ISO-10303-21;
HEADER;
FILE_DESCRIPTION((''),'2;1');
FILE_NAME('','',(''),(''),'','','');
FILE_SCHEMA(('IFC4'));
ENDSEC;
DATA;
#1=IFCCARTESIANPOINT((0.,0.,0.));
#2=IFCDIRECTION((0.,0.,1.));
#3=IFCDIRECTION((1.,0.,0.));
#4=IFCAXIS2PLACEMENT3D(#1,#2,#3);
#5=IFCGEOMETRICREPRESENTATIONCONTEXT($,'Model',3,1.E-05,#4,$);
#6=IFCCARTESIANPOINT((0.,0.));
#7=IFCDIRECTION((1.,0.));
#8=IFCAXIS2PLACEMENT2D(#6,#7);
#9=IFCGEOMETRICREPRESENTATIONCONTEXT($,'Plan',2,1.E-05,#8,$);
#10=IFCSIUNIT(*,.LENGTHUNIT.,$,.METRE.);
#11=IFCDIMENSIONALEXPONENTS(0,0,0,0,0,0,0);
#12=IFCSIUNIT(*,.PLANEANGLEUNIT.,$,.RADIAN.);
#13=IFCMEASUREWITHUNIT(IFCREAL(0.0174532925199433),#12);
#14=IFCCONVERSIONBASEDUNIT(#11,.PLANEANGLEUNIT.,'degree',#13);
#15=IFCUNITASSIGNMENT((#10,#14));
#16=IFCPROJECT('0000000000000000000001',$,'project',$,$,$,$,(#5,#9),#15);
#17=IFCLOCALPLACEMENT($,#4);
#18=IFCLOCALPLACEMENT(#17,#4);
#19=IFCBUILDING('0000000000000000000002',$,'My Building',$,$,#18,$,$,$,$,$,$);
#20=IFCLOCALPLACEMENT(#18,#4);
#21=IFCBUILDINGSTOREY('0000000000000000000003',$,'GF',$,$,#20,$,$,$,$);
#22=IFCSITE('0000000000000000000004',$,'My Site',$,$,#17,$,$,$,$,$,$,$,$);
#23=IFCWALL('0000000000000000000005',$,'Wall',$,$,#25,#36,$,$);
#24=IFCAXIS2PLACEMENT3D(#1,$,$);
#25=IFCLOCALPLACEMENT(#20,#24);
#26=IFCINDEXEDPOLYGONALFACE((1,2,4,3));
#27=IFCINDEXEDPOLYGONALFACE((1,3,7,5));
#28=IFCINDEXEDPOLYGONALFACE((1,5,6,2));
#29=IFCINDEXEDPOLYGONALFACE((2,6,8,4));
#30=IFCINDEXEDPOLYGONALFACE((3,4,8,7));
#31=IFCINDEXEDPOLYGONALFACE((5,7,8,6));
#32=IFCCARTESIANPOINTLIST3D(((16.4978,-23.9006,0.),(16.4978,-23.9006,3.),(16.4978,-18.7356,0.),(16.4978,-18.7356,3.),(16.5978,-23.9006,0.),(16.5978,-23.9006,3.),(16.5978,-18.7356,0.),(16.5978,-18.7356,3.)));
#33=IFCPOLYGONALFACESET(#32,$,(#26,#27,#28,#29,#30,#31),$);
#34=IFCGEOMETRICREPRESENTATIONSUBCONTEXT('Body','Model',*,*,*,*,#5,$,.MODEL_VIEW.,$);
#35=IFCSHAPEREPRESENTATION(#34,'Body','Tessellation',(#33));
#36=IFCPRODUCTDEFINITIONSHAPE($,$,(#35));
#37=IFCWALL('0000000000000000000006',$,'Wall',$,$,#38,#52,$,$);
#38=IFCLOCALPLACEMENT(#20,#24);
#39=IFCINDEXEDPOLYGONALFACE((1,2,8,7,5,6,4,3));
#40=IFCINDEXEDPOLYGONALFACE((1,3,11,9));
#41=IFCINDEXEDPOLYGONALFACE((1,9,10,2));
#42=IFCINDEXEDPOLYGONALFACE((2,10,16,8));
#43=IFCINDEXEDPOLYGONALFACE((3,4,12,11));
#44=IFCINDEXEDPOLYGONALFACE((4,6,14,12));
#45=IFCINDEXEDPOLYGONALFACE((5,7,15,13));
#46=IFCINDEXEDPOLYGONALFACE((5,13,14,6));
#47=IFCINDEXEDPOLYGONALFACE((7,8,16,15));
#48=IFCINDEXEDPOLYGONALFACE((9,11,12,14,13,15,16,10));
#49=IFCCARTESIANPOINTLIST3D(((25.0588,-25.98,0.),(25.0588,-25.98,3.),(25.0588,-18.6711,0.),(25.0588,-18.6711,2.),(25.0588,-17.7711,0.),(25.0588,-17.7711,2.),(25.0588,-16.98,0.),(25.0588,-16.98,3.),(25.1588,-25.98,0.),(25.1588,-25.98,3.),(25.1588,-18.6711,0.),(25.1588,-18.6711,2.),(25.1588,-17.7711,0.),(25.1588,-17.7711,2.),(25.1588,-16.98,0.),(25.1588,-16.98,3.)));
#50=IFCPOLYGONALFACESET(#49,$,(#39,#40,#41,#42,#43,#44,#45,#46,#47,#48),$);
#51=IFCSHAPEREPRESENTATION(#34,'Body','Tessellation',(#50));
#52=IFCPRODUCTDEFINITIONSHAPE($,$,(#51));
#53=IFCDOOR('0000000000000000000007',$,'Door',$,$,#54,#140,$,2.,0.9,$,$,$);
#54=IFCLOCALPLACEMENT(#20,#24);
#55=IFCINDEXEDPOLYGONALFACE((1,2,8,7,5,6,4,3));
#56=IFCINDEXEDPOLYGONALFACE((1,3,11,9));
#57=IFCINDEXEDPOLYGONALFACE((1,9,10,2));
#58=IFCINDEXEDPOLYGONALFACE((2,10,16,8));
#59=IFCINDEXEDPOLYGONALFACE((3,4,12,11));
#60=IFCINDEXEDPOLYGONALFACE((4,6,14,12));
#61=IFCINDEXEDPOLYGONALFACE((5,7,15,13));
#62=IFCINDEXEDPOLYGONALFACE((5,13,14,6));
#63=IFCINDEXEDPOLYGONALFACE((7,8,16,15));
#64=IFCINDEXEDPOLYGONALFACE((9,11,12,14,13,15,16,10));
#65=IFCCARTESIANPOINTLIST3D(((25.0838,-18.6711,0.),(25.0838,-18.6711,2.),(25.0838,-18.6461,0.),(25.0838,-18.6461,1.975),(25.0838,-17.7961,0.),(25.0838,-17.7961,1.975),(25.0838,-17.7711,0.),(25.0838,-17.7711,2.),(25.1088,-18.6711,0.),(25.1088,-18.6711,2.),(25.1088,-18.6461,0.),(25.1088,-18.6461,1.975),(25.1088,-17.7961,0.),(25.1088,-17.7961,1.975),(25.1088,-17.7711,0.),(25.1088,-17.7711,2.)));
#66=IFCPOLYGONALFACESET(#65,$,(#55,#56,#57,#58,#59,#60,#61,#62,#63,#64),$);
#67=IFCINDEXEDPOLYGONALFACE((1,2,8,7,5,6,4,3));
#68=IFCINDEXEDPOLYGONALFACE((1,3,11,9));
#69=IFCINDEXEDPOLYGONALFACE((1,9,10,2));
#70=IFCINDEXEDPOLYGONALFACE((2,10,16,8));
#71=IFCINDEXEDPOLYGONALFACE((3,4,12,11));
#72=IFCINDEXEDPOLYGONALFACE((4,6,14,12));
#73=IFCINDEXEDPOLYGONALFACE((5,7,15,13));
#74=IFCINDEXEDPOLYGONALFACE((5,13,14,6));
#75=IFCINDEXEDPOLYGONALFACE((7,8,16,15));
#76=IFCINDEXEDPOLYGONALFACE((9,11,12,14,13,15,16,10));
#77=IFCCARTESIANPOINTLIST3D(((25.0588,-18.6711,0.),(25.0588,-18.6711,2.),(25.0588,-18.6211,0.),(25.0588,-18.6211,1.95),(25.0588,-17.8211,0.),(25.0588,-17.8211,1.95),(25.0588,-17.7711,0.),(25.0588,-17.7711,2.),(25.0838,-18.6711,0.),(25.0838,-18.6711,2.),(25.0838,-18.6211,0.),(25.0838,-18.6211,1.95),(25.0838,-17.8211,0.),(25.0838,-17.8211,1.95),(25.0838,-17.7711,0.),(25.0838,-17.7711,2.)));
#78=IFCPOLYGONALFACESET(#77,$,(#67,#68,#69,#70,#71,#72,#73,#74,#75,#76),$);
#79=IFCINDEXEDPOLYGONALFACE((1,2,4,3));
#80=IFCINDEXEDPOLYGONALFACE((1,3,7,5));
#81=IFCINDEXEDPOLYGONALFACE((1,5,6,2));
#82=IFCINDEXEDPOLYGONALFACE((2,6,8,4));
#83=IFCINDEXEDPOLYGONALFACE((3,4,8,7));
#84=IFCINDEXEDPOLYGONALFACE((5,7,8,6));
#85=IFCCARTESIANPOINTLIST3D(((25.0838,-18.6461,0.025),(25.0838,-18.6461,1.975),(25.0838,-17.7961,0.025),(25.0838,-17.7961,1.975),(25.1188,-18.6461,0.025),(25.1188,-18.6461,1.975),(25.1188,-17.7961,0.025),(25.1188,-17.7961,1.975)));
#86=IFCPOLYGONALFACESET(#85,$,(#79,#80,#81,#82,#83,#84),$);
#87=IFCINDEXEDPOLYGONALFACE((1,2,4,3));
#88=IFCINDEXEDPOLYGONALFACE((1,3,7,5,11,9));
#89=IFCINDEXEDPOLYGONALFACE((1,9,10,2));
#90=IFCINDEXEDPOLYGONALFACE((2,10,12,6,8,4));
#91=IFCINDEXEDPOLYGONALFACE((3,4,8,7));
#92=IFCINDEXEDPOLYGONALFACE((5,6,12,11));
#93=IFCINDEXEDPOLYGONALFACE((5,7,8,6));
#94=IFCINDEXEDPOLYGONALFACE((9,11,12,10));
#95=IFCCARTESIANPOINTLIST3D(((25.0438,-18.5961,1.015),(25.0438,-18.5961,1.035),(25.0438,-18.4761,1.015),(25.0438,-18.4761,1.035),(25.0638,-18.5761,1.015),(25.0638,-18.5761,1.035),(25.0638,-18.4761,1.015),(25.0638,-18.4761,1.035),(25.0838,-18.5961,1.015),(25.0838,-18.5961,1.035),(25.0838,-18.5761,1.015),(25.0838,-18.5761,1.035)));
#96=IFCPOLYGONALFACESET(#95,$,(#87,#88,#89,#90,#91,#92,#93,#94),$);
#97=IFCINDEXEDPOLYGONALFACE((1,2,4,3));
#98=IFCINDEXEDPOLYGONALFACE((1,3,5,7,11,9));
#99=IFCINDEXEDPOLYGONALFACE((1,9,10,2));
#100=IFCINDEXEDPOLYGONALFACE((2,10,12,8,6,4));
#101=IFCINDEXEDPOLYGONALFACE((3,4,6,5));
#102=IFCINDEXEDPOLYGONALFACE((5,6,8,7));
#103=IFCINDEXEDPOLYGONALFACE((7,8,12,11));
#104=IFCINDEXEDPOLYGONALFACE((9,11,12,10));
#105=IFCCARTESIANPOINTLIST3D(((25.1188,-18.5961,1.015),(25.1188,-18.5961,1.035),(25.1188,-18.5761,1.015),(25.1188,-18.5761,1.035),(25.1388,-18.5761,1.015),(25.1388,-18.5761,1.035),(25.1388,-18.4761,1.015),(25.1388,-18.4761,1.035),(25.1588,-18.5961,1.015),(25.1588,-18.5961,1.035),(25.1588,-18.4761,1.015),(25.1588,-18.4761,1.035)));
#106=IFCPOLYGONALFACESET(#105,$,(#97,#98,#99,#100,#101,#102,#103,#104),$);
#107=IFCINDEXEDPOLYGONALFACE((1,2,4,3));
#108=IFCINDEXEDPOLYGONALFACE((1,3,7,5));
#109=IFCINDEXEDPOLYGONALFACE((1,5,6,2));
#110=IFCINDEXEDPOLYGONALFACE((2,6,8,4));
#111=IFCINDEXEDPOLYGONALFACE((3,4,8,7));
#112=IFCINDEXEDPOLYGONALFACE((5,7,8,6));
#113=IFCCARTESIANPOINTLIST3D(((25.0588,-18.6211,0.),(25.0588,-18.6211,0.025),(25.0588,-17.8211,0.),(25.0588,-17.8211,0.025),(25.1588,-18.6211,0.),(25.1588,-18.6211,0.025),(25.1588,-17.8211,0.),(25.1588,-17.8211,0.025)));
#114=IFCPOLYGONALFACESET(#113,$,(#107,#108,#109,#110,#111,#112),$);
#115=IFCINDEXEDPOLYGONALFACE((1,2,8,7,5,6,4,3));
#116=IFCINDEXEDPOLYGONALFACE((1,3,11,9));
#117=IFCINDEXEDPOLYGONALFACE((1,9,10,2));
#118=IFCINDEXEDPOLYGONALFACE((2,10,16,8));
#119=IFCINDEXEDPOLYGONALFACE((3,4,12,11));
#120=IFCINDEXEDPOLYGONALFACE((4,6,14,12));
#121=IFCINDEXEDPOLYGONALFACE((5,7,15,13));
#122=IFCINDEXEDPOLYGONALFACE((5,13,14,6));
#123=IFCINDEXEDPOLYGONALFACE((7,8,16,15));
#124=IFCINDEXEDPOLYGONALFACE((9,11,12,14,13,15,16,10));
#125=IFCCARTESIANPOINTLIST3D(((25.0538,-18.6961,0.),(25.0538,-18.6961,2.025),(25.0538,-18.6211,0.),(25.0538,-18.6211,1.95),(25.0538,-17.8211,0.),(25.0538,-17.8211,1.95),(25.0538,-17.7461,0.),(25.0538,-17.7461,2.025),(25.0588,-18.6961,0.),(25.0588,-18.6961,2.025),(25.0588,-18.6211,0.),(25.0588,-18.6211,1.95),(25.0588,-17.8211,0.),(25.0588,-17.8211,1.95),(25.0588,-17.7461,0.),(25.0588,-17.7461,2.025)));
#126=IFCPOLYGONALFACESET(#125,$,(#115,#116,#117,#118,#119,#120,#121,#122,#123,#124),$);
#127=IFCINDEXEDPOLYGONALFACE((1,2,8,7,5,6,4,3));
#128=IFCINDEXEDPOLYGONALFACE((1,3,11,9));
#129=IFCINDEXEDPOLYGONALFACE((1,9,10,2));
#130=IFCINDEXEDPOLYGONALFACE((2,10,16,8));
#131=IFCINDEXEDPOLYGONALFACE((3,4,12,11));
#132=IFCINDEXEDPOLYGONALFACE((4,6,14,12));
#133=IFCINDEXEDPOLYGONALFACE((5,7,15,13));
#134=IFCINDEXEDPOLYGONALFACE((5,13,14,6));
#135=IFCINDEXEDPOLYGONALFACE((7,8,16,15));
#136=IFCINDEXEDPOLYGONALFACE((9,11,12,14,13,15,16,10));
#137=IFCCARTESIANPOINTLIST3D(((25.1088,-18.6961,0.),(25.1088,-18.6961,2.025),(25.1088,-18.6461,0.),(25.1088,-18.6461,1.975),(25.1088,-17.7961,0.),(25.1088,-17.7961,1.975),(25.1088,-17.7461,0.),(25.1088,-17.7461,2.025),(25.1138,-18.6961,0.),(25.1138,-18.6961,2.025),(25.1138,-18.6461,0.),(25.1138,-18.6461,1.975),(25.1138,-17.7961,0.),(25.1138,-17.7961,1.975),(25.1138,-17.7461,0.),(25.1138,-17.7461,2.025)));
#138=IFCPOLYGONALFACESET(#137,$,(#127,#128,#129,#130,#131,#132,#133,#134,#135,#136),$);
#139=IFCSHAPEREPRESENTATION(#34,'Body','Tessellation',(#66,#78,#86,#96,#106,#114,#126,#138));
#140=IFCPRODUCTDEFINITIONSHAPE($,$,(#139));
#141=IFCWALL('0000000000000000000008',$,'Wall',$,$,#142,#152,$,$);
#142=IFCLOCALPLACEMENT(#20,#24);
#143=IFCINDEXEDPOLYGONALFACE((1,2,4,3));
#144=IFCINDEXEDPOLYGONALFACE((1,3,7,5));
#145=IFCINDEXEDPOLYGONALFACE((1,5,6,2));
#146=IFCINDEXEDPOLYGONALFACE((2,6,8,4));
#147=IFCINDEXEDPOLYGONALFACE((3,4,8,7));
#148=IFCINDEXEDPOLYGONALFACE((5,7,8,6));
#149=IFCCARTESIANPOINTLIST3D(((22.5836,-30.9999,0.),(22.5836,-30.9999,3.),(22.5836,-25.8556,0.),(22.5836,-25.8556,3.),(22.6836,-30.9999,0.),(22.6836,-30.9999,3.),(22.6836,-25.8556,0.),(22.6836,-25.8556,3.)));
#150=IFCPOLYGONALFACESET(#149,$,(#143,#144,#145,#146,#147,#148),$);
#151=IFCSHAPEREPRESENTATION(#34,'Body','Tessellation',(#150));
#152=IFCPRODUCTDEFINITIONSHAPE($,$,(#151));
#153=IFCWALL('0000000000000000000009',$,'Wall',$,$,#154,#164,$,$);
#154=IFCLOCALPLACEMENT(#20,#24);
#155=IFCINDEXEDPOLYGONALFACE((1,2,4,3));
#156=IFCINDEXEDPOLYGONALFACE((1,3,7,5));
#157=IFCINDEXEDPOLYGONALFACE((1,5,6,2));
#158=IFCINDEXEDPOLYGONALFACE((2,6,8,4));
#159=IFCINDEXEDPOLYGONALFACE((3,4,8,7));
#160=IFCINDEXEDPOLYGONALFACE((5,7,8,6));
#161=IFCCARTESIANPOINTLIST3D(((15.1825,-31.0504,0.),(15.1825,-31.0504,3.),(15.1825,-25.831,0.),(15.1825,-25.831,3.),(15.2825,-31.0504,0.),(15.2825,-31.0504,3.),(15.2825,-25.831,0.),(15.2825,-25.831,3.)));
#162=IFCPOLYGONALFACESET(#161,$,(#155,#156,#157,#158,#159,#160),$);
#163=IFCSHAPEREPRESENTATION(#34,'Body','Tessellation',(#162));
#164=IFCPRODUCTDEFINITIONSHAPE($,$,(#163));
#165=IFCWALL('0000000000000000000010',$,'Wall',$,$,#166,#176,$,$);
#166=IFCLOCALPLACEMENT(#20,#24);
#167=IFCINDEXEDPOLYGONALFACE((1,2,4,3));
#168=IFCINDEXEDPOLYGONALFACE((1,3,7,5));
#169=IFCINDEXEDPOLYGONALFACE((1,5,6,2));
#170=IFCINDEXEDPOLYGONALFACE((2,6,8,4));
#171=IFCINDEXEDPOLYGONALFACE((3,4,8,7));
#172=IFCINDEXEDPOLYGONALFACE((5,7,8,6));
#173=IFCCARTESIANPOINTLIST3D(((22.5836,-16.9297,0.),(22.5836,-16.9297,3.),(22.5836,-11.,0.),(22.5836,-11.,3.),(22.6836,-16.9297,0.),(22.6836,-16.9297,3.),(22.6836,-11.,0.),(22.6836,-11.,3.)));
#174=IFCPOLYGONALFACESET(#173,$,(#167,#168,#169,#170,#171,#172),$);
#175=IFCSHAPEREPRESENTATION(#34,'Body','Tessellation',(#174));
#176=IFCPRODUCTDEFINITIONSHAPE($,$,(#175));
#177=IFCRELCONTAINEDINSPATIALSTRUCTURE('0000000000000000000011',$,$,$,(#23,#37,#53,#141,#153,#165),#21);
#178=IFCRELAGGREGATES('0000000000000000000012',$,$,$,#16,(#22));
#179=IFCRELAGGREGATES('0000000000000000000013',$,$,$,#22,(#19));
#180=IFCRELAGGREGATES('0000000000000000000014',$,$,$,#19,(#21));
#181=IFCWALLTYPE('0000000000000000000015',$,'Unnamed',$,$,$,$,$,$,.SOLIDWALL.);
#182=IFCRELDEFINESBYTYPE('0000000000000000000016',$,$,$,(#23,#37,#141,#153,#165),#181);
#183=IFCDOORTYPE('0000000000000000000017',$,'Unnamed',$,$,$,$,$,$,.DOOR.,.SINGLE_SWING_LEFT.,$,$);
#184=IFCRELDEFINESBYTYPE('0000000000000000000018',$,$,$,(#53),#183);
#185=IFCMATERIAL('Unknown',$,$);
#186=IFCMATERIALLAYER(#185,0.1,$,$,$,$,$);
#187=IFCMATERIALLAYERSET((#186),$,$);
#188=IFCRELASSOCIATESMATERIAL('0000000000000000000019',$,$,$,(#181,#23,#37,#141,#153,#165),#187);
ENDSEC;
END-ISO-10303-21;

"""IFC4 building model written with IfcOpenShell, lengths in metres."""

from ifc_helpers import new_model, entity, si_unit, converted_unit, frame, origin_with_axes, origin_2d_with_axis, place, context, subcontext, project, spatial, line, indexed_curve, outline, extrude, shape, source, transform, mapped, material, layer, layer_set, layer_usage, type_object, type_shapes, element, fill, save


model = new_model("IFC4")

# Units and contexts
model_context = context("Model", 3, precision=1e-05, world=origin_with_axes())
plan_context = context("Plan", 2, precision=1e-05, world=origin_2d_with_axis())
body_context_1 = subcontext(model_context, "Body", "Model", "MODEL_VIEW")
body_context_2 = subcontext(plan_context, "Body", "Plan", "PLAN_VIEW")
ifc_project = project(units=[si_unit("LENGTHUNIT", "METRE"), converted_unit("PLANEANGLEUNIT", "degree", entity("IfcReal", 0.0174532925199433), si_unit("PLANEANGLEUNIT", "RADIAN"), dimensions=[0, 0, 0, 0, 0, 0, 0])], contexts=[model_context, plan_context])

# Site, building, storey
site_placement = place(None, origin_with_axes())
site = spatial("IfcSite", under=ifc_project, at=site_placement, Name="My Site")
building_placement = place(site_placement, origin_with_axes())
building = spatial("IfcBuilding", under=site, at=building_placement, Name="My Building")
storey_placement = place(building_placement, origin_with_axes())
storey = spatial("IfcBuildingStorey", under=building, at=storey_placement, Name="GF")

# Shared definitions
ifc_material = material(Name="Unknown")
ifc_layer = layer(ifc_material, 0.1)
ifc_layer_set = layer_set([ifc_layer])
wall_type = type_object("IfcWallType", Name="Unnamed", PredefinedType="SOLIDWALL", material=ifc_layer_set)

# Shared definitions
shared_shape_1 = source(origin_with_axes(), body_context_1, "Body", "SweptSolid", [
    extrude(outline(indexed_curve([(0.0, 0.0), (0.9, 0.0), (0.9, 2.0), (0.0, 2.0)], segments=[line(1, 2, 3, 4, 1)])), frame((0.0, -0.6, 0.0), z_axis=(0.0, -1.0, 0.0), x_axis=(1.0, 0.0, 0.0)), (0.0, 0.0, -1.0), 1.2),
])
door_type = type_object("IfcDoorType", Name="Unnamed", OperationType="SINGLE_SWING_LEFT", PredefinedType="DOOR")
shared_shape_2 = source(origin_with_axes(), body_context_1, "Body", "SweptSolid", [
    extrude(outline(indexed_curve([(0.0, 0.0), (0.0, 2.0), (0.9, 2.0), (0.9, 0.0), (0.875, 0.0), (0.875, 1.975), (0.025, 1.975), (0.025, 0.0)], segments=[line(1, 2, 3, 4, 5, 6, 7, 8, 1)])), frame((0.0, 0.025, 0.0), z_axis=(0.0, -1.0, 0.0), x_axis=(1.0, 0.0, 0.0)), (0.0, 0.0, -1.0), 0.025),
    extrude(outline(indexed_curve([(0.0, 0.0), (0.0, 2.0), (0.9, 2.0), (0.9, 0.0), (0.85, 0.0), (0.85, 1.95), (0.05, 1.95), (0.05, 0.0)], segments=[line(1, 2, 3, 4, 5, 6, 7, 8, 1)])), frame((0.0, 0.0, 0.0), z_axis=(0.0, -1.0, 0.0), x_axis=(1.0, 0.0, 0.0)), (0.0, 0.0, -1.0), 0.025),
    extrude(outline(indexed_curve([(0.0, 0.0), (0.85, 0.0), (0.85, 0.035), (0.0, 0.035)], segments=[line(1, 2, 3, 4, 1)])), frame((0.025, 0.025, 0.025), z_axis=(0.0, 0.0, 1.0), x_axis=(1.0, 0.0, 0.0)), (0.0, 0.0, 1.0), 1.95),
    extrude(outline(indexed_curve([(0.0, 0.0), (0.0, -0.04), (-0.12, -0.04), (-0.12, -0.02), (-0.02, -0.02), (-0.02, 0.0)], segments=[line(1, 2, 3, 4, 5, 6, 1)])), frame((0.825, 0.025, 1.015), z_axis=(0.0, 0.0, 1.0), x_axis=(1.0, 0.0, 0.0)), (0.0, 0.0, 1.0), 0.02),
    extrude(outline(indexed_curve([(0.0, 0.0), (0.0, 0.04), (-0.12, 0.04), (-0.12, 0.02), (-0.02, 0.02), (-0.02, 0.0)], segments=[line(1, 2, 3, 4, 5, 6, 1)])), frame((0.825, 0.06, 1.015), z_axis=(0.0, 0.0, 1.0), x_axis=(1.0, 0.0, 0.0)), (0.0, 0.0, 1.0), 0.02),
    extrude(outline(indexed_curve([(0.0, 0.0), (0.8, 0.0), (0.8, 0.1), (0.0, 0.1)], segments=[line(1, 2, 3, 4, 1)])), frame((0.05, 0.0, 0.0), z_axis=(0.0, 0.0, 1.0), x_axis=(1.0, 0.0, 0.0)), (0.0, 0.0, 1.0), 0.025),
    extrude(outline(indexed_curve([(0.0, 0.0), (0.0, 2.025), (0.95, 2.025), (0.95, 0.0), (0.875, 0.0), (0.875, 1.95), (0.075, 1.95), (0.075, 0.0)], segments=[line(1, 2, 3, 4, 5, 6, 7, 8, 1)])), frame((-0.025, -0.005, 0.0), z_axis=(0.0, -1.0, 0.0), x_axis=(1.0, 0.0, 0.0)), (0.0, 0.0, -1.0), 0.005),
    extrude(outline(indexed_curve([(0.0, 0.0), (0.0, 2.025), (0.95, 2.025), (0.95, 0.0), (0.9, 0.0), (0.9, 1.975), (0.05, 1.975), (0.05, 0.0)], segments=[line(1, 2, 3, 4, 5, 6, 7, 8, 1)])), frame((-0.025, 0.05, 0.0), z_axis=(0.0, -1.0, 0.0), x_axis=(1.0, 0.0, 0.0)), (0.0, 0.0, -1.0), 0.005),
])
shared_shape_3 = source(origin_with_axes(), body_context_2, "Body", "Curve2D", [
    entity("IfcIndexedPolyCurve", entity("IfcCartesianPointList2D", [[0.0, 0.0], [0.0, 0.05], [0.025, 0.05], [0.025, 0.025], [0.05, 0.025], [0.05, 0.0]]), [entity("IfcLineIndex", [1, 2, 3, 4, 5, 6, 1])]),
    entity("IfcIndexedPolyCurve", entity("IfcCartesianPointList2D", [[0.9, 0.0], [0.9, 0.05], [0.875, 0.05], [0.875, 0.025], [0.85, 0.025], [0.85, 0.0]]), [entity("IfcLineIndex", [1, 2, 3, 4, 5, 6, 1])]),
    entity("IfcTrimmedCurve", entity("IfcEllipse", entity("IfcAxis2Placement2D", entity("IfcCartesianPoint", [0.06, 0.05]), entity("IfcDirection", [1.0, 0.0])), 0.815, 0.85), [entity("IfcCartesianPoint", [0.875, 0.05])], [entity("IfcCartesianPoint", [0.06, 0.9])], True, "CARTESIAN"),
    entity("IfcIndexedPolyCurve", entity("IfcCartesianPointList2D", [[0.025, 0.05], [0.06, 0.05], [0.06, 0.9], [0.025, 0.9]]), [entity("IfcLineIndex", [1, 2, 3, 4, 1])]),
])
type_shapes(door_type, [shared_shape_2, shared_shape_3])

# Wall
ifc_layer_usage_1 = layer_usage(ifc_layer_set, "AXIS2", "POSITIVE", 0.0)
wall_1_placement = place(storey_placement, frame((16.4978, -18.7356, 0.0), z_axis=(0.0, 0.0, 1.0), x_axis=(0.0, -1.0, 0.0)))
element("IfcWall", 1, at=wall_1_placement, inside=storey, type_object=wall_type, material=ifc_layer_usage_1, Name="Wall", context=body_context_1, shape_type="SweptSolid", body=[
    extrude(outline(indexed_curve([(0.0, 0.0), (0.0, 0.1), (5.1651, 0.1), (5.1651, 0.0)], segments=[line(1, 2, 3, 4, 1)])), origin_with_axes(), (0.0, 0.0, 1.0), 3.0),
])

# Wall, opening, door
ifc_layer_usage_2 = layer_usage(ifc_layer_set, "AXIS2", "POSITIVE", 0.0)
wall_2_placement = place(storey_placement, frame((25.0588, -16.98, 0.0), z_axis=(0.0, 0.0, 1.0), x_axis=(0.0, -1.0, 0.0)))
wall_2 = element("IfcWall", 2, at=wall_2_placement, inside=storey, type_object=wall_type, material=ifc_layer_usage_2, Name="Wall", context=body_context_1, shape_type="SweptSolid", body=[
    extrude(outline(indexed_curve([(0.0, 0.0), (0.0, 0.1), (9.0, 0.1), (9.0, 0.0)], segments=[line(1, 2, 3, 4, 1)])), origin_with_axes(), (0.0, 0.0, 1.0), 3.0),
])
opening_1_placement = place(wall_2_placement, frame((0.7911, 0.0, 0.0), z_axis=(0.0, 0.0, 1.0), x_axis=(1.0, 0.0, 0.0)))
opening_1 = element("IfcOpeningElement", 3, at=opening_1_placement, cuts=wall_2, PredefinedType="OPENING", context=body_context_1, shape_type="MappedRepresentation", body=[
    mapped(shared_shape_1, transform((0.0, 0.0, 0.0), x_axis=(1.0, 0.0, 0.0), y_axis=(0.0, 1.0, 0.0), z_axis=(0.0, 0.0, 1.0), scale=1.0)),
])
door_1_placement = place(opening_1_placement, frame((0.0, 0.0, 0.0), z_axis=(0.0, 0.0, 1.0), x_axis=(1.0, 0.0, 0.0)))
door_1 = element("IfcDoor", 4, at=door_1_placement, inside=storey, type_object=door_type, Name="Door", OverallHeight=2.0, OverallWidth=0.9, shapes=[
    shape(body_context_1, "Body", "MappedRepresentation", [mapped(shared_shape_2, transform((0.0, 0.0, 0.0), x_axis=(1.0, 0.0, 0.0), y_axis=(0.0, 1.0, 0.0), z_axis=(0.0, 0.0, 1.0), scale=1.0))]),
    shape(body_context_2, "Body", "MappedRepresentation", [mapped(shared_shape_3, transform((0.0, 0.0, 0.0), x_axis=(1.0, 0.0, 0.0), y_axis=(0.0, 1.0, 0.0), z_axis=(0.0, 0.0, 1.0), scale=1.0))]),
])
fill(opening_1, door_1)

# Walls
ifc_layer_usage_3 = layer_usage(ifc_layer_set, "AXIS2", "POSITIVE", 0.0)
wall_3_placement = place(storey_placement, frame((22.5836, -25.8556, 0.0), z_axis=(0.0, 0.0, 1.0), x_axis=(0.0, -1.0, 0.0)))
element("IfcWall", 5, at=wall_3_placement, inside=storey, type_object=wall_type, material=ifc_layer_usage_3, Name="Wall", context=body_context_1, shape_type="SweptSolid", body=[
    extrude(outline(indexed_curve([(0.0, 0.0), (0.0, 0.1), (5.1443, 0.1), (5.1443, 0.0)], segments=[line(1, 2, 3, 4, 1)])), origin_with_axes(), (0.0, 0.0, 1.0), 3.0),
])
ifc_layer_usage_4 = layer_usage(ifc_layer_set, "AXIS2", "POSITIVE", 0.0)
wall_4_placement = place(storey_placement, frame((15.1825, -25.831, 0.0), z_axis=(0.0, 0.0, 1.0), x_axis=(0.0, -1.0, 0.0)))
element("IfcWall", 6, at=wall_4_placement, inside=storey, type_object=wall_type, material=ifc_layer_usage_4, Name="Wall", context=body_context_1, shape_type="SweptSolid", body=[
    extrude(outline(indexed_curve([(0.0, 0.0), (0.0, 0.1), (5.2194, 0.1), (5.2194, 0.0)], segments=[line(1, 2, 3, 4, 1)])), origin_with_axes(), (0.0, 0.0, 1.0), 3.0),
])
ifc_layer_usage_5 = layer_usage(ifc_layer_set, "AXIS2", "POSITIVE", 0.0)
wall_5_placement = place(storey_placement, frame((22.5836, -11.0, 0.0), z_axis=(0.0, 0.0, 1.0), x_axis=(0.000001, -1.0, 0.0)))
element("IfcWall", 7, at=wall_5_placement, inside=storey, type_object=wall_type, material=ifc_layer_usage_5, Name="Wall", context=body_context_1, shape_type="SweptSolid", body=[
    extrude(outline(indexed_curve([(0.0, 0.0), (0.0, 0.1), (5.9297, 0.1), (5.9297, 0.0)], segments=[line(1, 2, 3, 4, 1)])), origin_with_axes(), (0.0, 0.0, 1.0), 3.0),
])

save(model, "model.ifc")
